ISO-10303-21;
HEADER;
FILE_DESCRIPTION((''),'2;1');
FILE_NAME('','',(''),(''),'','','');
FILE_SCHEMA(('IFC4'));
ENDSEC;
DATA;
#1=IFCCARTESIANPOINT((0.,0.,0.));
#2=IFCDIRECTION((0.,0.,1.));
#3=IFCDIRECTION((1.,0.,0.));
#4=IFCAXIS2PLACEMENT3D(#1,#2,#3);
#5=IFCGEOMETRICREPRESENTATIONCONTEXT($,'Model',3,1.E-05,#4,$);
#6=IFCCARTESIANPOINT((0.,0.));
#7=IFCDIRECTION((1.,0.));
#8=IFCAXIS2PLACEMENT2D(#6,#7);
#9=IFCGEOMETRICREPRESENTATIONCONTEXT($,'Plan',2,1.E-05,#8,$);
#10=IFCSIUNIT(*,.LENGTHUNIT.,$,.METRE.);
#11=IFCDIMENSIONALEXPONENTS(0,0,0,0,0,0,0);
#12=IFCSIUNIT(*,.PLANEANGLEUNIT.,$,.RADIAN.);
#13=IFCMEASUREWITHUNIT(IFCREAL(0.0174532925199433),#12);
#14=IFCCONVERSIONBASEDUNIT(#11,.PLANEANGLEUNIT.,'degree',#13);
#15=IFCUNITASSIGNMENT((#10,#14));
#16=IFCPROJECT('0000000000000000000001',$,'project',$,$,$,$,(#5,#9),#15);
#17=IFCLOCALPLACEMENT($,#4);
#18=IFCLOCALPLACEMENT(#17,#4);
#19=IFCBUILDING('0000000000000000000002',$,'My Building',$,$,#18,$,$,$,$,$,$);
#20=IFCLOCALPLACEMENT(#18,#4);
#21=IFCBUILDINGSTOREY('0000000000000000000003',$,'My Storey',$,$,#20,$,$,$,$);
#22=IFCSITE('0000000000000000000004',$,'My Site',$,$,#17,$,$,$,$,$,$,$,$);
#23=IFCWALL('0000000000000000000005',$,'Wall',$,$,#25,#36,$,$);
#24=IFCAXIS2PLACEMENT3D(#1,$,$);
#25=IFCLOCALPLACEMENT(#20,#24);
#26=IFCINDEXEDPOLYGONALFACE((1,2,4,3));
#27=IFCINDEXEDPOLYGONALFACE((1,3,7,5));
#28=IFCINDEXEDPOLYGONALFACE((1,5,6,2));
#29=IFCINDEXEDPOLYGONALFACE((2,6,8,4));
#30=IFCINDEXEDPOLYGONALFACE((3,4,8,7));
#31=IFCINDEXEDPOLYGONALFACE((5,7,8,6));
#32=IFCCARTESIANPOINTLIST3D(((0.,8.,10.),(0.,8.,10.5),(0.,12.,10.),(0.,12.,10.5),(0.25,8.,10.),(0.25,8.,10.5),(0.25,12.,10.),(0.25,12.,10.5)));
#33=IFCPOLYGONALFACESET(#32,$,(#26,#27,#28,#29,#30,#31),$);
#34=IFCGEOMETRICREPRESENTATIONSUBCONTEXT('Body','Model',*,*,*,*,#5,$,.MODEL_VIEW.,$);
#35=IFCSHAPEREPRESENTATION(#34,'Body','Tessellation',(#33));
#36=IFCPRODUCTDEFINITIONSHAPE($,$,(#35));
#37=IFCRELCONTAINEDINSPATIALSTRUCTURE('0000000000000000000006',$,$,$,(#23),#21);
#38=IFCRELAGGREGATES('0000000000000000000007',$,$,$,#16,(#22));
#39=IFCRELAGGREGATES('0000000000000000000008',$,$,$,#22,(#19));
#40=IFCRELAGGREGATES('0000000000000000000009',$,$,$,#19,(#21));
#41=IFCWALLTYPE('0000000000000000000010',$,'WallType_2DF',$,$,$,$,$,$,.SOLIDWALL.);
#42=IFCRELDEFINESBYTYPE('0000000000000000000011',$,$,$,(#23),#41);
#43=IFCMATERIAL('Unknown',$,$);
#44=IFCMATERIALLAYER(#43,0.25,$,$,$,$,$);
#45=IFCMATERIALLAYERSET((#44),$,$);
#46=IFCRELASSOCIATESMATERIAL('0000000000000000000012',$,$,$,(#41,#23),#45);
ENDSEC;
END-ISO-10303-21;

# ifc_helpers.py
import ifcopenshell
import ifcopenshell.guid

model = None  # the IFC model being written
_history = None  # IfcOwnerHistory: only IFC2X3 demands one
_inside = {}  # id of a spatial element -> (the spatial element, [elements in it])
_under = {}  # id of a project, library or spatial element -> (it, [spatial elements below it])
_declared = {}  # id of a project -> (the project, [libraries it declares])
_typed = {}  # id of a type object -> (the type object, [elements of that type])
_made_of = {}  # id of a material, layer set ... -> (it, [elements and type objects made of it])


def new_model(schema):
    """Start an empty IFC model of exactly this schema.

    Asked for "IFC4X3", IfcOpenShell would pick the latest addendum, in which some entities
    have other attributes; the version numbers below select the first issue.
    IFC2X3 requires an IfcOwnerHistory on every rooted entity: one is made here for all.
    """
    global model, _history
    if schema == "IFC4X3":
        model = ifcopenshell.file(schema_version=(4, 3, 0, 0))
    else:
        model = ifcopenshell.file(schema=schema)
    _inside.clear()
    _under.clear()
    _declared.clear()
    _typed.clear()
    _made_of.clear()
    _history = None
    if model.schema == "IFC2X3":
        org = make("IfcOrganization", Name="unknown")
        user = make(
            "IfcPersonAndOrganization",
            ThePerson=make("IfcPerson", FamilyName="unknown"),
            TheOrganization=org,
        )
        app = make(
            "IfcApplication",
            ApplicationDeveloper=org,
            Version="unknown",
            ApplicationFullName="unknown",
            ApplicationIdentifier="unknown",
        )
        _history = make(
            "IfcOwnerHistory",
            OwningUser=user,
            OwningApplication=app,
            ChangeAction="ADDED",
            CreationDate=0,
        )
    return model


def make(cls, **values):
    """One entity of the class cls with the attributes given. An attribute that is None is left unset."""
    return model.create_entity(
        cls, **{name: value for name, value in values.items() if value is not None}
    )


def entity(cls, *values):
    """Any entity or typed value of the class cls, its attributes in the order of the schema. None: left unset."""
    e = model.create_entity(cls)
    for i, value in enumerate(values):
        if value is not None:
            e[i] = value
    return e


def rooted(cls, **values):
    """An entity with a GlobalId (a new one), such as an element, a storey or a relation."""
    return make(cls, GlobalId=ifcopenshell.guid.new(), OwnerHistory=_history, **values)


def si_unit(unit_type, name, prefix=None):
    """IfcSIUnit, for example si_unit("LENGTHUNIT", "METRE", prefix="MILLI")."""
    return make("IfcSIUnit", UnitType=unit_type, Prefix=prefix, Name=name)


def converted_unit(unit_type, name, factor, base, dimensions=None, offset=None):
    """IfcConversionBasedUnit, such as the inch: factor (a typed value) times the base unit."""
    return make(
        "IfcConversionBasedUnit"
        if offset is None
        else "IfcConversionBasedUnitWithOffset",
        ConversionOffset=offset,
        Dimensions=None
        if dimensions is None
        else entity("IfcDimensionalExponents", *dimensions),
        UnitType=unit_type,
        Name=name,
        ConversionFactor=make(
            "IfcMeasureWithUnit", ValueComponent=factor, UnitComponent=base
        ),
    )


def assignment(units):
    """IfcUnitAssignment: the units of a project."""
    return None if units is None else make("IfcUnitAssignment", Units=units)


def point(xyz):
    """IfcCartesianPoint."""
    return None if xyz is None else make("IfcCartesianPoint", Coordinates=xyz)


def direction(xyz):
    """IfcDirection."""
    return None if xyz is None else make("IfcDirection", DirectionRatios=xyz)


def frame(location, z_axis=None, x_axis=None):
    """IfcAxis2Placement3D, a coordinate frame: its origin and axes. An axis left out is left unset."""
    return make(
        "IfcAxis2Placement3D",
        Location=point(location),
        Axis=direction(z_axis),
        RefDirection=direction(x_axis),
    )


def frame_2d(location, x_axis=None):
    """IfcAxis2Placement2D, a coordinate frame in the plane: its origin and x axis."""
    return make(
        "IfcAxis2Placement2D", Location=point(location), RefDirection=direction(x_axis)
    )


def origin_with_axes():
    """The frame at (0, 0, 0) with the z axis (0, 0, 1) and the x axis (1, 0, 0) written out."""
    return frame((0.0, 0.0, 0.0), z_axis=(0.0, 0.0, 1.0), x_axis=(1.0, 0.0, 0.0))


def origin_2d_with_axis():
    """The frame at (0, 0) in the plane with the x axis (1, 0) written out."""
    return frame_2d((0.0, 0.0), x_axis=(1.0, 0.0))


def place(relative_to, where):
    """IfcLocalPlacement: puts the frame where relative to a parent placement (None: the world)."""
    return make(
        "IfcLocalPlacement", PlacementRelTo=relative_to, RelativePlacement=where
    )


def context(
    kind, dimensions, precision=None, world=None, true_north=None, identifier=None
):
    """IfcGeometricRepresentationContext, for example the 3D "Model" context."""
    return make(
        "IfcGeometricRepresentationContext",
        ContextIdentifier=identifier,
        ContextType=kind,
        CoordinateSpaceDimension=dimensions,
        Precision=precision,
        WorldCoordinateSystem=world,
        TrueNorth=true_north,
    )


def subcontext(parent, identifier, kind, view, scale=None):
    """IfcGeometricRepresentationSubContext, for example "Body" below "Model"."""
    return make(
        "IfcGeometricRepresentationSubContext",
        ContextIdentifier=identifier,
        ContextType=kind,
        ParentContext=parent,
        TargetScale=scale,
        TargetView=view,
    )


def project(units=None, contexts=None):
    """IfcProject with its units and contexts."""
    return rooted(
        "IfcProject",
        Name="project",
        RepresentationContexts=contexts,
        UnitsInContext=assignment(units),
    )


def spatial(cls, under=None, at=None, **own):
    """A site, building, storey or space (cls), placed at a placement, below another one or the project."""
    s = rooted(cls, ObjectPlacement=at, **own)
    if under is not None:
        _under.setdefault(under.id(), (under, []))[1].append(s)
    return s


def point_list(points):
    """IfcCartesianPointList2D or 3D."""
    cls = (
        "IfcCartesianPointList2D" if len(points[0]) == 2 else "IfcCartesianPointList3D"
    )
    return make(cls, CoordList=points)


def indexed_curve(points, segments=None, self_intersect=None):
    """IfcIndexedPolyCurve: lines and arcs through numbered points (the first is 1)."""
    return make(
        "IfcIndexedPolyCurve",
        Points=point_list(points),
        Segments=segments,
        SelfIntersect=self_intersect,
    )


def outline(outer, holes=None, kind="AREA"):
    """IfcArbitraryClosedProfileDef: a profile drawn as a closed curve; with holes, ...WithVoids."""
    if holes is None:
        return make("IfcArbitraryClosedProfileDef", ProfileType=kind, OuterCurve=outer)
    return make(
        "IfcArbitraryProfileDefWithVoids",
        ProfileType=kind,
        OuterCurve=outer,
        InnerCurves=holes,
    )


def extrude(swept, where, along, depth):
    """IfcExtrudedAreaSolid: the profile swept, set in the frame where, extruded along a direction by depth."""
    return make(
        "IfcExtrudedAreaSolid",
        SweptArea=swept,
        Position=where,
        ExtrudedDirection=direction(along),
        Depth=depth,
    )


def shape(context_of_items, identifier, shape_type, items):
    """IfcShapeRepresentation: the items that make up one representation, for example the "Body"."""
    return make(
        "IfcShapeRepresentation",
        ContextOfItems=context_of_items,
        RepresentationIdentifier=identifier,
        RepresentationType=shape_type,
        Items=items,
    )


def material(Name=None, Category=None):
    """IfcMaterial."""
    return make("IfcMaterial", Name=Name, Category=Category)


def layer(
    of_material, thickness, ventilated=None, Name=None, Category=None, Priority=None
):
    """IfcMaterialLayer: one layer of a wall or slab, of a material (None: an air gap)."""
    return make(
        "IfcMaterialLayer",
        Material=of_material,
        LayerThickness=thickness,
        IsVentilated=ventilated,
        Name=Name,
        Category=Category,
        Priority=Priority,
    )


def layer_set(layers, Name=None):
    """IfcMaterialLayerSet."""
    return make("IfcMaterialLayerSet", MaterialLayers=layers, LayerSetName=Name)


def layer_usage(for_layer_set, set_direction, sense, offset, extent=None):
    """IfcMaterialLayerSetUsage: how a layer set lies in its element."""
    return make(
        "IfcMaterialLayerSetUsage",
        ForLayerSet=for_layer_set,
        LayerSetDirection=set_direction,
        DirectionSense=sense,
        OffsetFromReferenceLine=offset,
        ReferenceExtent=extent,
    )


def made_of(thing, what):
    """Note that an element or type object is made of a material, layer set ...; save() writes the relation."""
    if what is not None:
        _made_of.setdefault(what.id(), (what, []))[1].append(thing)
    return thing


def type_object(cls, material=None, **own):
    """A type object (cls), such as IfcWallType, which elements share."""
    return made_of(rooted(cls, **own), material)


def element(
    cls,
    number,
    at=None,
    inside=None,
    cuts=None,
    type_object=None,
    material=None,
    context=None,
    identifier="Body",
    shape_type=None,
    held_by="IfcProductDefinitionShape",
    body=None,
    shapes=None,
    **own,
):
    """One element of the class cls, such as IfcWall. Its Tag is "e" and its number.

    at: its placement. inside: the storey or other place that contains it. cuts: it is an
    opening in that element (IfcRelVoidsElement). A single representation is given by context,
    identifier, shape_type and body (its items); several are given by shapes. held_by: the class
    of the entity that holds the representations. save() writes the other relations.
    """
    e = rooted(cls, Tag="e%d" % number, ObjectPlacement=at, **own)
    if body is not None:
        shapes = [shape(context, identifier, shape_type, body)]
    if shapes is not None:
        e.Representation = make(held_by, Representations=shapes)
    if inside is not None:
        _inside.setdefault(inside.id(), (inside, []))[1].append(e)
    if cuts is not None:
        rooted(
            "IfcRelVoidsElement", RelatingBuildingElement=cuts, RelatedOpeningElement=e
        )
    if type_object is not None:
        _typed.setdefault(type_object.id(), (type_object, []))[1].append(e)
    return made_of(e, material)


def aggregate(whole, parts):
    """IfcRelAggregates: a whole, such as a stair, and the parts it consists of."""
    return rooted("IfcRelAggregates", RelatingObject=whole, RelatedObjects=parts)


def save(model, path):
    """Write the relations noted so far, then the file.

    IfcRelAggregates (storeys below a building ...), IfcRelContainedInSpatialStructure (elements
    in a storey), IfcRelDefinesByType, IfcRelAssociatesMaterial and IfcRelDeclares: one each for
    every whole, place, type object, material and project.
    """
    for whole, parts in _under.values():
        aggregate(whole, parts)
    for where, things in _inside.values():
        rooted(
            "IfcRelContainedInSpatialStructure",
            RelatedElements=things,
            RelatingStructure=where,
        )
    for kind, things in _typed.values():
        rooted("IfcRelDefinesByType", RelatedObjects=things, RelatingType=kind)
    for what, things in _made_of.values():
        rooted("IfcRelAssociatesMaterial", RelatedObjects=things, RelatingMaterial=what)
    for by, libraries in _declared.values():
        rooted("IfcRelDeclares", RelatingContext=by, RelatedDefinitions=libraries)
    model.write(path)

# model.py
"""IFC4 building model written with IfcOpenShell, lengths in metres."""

from ifc_helpers import new_model, entity, si_unit, converted_unit, frame, origin_with_axes, origin_2d_with_axis, place, context, subcontext, project, spatial, indexed_curve, outline, extrude, material, layer, layer_set, layer_usage, type_object, element, save


model = new_model("IFC4")

# Units and contexts
model_context = context("Model", 3, precision=1e-05, world=origin_with_axes())
plan_context = context("Plan", 2, precision=1e-05, world=origin_2d_with_axis())
body_context_1 = subcontext(model_context, "Body", "Model", "MODEL_VIEW")
ifc_project = project(units=[si_unit("LENGTHUNIT", "METRE"), converted_unit("PLANEANGLEUNIT", "degree", entity("IfcReal", 0.0174532925199433), si_unit("PLANEANGLEUNIT", "RADIAN"), dimensions=[0, 0, 0, 0, 0, 0, 0])], contexts=[model_context, plan_context])

# Site, building, storey
site_placement = place(None, origin_with_axes())
site = spatial("IfcSite", under=ifc_project, at=site_placement, Name="My Site")
building_placement = place(site_placement, origin_with_axes())
building = spatial("IfcBuilding", under=site, at=building_placement, Name="My Building")
storey_placement = place(building_placement, origin_with_axes())
storey = spatial("IfcBuildingStorey", under=building, at=storey_placement, Name="My Storey")

# Shared definitions
ifc_material = material(Name="Unknown")
ifc_layer = layer(ifc_material, 0.25)
ifc_layer_set = layer_set([ifc_layer])
wall_type = type_object("IfcWallType", Name="WallType_2DF", PredefinedType="SOLIDWALL", material=ifc_layer_set)

# Wall
ifc_layer_usage_1 = layer_usage(ifc_layer_set, "AXIS2", "POSITIVE", 0.0)
wall_1_placement = place(storey_placement, frame((0.25, 8.0, 10.0), z_axis=(0.0, 0.0, 1.0), x_axis=(0.0, 1.0, 0.0)))
element("IfcWall", 1, at=wall_1_placement, inside=storey, type_object=wall_type, material=ifc_layer_usage_1, Name="Wall", context=body_context_1, shape_type="SweptSolid", body=[
    extrude(outline(indexed_curve([(0.0, 0.0), (0.0, 0.25), (4.0, 0.25), (4.0, 0.0), (0.0, 0.0)], self_intersect=False)), origin_with_axes(), (0.0, 0.0, 1.0), 0.5),
])

save(model, "model.ifc")
